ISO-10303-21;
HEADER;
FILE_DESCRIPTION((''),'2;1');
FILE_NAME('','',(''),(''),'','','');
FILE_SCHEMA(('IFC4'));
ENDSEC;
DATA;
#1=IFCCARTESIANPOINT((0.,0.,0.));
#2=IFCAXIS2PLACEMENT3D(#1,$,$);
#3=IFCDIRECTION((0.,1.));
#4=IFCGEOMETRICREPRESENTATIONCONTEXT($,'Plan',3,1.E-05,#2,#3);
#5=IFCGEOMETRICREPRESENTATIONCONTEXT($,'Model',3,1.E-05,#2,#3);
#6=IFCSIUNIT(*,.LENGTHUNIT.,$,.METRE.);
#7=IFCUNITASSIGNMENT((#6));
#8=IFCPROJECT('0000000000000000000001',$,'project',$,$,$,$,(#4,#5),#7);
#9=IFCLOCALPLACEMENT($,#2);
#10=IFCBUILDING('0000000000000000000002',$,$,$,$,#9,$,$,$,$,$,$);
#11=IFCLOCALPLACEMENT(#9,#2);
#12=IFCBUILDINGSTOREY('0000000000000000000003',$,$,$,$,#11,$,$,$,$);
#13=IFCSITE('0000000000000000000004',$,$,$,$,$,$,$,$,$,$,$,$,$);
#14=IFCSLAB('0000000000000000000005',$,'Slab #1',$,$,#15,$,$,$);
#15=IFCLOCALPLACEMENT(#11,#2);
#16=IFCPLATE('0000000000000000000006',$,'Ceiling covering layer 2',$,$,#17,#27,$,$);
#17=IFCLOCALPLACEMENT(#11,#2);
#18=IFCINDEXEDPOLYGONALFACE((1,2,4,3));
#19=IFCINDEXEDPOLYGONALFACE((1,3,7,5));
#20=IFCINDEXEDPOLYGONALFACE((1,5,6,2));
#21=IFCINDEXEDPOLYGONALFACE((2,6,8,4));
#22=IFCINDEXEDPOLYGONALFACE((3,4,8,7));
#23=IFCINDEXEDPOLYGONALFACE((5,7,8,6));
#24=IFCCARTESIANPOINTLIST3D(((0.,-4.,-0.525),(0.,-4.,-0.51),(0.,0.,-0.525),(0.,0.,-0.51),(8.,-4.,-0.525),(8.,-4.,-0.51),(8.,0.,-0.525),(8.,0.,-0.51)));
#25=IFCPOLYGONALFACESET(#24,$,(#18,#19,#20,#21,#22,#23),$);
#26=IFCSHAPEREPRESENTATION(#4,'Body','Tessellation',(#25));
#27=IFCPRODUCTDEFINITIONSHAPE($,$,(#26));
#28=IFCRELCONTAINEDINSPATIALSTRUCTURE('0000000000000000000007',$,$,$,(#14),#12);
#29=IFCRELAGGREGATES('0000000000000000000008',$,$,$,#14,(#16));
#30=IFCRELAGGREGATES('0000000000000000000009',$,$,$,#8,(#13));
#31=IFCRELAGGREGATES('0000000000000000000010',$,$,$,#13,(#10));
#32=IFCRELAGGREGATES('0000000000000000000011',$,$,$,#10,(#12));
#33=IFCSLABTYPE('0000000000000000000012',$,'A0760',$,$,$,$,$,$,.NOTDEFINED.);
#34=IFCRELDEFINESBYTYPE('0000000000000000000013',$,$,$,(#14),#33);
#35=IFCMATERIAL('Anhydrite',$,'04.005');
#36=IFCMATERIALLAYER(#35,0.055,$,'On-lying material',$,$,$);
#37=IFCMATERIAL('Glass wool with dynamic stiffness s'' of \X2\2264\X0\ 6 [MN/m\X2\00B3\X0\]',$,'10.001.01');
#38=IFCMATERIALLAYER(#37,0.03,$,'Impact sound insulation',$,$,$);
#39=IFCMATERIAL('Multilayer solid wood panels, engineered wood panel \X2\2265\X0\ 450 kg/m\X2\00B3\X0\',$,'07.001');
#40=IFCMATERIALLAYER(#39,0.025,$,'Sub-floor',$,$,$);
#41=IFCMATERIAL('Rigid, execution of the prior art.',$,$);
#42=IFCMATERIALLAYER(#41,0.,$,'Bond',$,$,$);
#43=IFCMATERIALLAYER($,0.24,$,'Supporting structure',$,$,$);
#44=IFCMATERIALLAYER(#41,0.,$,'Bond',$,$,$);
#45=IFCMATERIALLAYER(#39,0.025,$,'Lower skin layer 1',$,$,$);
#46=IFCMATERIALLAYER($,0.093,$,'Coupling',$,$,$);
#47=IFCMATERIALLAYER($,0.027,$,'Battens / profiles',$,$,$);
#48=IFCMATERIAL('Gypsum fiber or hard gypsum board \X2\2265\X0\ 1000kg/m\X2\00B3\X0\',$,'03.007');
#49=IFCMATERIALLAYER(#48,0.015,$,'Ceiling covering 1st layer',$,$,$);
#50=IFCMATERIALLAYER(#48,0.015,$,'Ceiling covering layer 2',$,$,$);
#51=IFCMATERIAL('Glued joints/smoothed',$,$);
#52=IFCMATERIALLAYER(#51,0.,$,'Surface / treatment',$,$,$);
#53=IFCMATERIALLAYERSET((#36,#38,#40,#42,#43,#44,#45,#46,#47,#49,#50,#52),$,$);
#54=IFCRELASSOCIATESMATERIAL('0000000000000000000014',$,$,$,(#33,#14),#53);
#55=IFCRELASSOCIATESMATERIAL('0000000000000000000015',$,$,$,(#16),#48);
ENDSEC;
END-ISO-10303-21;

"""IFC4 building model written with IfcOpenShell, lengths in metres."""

from ifc_helpers import new_model, si_unit, direction, frame, frame_2d, origin, place, context, project, spatial, rectangle, extrude, material, layer, layer_set, type_object, element, aggregate, save


model = new_model("IFC4")

# Units and contexts
plan_context = context("Plan", 3, precision=1e-05, world=origin(), true_north=direction((0.0, 1.0)))
model_context = context("Model", 3, precision=1e-05, world=origin(), true_north=direction((0.0, 1.0)))
ifc_project = project(units=[si_unit("LENGTHUNIT", "METRE")], contexts=[plan_context, model_context])

# Site, building, storey
site = spatial("IfcSite", under=ifc_project)
building_placement = place(None, origin())
building = spatial("IfcBuilding", under=site, at=building_placement)
storey_placement = place(building_placement, origin())
storey = spatial("IfcBuildingStorey", under=building, at=storey_placement)

# Slab, plate
ifc_material_1 = material(Name="Anhydrite", Category="04.005")
ifc_layer_1 = layer(ifc_material_1, 0.055, Name="On-lying material")
ifc_material_2 = material(Name="Glass wool with dynamic stiffness s' of ≤ 6 [MN/m³]", Category="10.001.01")
ifc_layer_2 = layer(ifc_material_2, 0.03, Name="Impact sound insulation")
ifc_material_3 = material(Name="Multilayer solid wood panels, engineered wood panel ≥ 450 kg/m³", Category="07.001")
ifc_layer_3 = layer(ifc_material_3, 0.025, Name="Sub-floor")
ifc_material_4 = material(Name="Rigid, execution of the prior art.")
ifc_layer_4 = layer(ifc_material_4, 0.0, Name="Bond")
ifc_layer_5 = layer(None, 0.24, Name="Supporting structure")
ifc_layer_6 = layer(ifc_material_4, 0.0, Name="Bond")
ifc_layer_7 = layer(ifc_material_3, 0.025, Name="Lower skin layer 1")
ifc_layer_8 = layer(None, 0.093, Name="Coupling")
ifc_layer_9 = layer(None, 0.027, Name="Battens / profiles")
ifc_material_5 = material(Name="Gypsum fiber or hard gypsum board ≥ 1000kg/m³", Category="03.007")
ifc_layer_10 = layer(ifc_material_5, 0.015, Name="Ceiling covering 1st layer")
ifc_layer_11 = layer(ifc_material_5, 0.015, Name="Ceiling covering layer 2")
ifc_material_6 = material(Name="Glued joints/smoothed")
ifc_layer_12 = layer(ifc_material_6, 0.0, Name="Surface / treatment")
ifc_layer_set = layer_set([ifc_layer_1, ifc_layer_2, ifc_layer_3, ifc_layer_4, ifc_layer_5, ifc_layer_6, ifc_layer_7, ifc_layer_8, ifc_layer_9, ifc_layer_10, ifc_layer_11, ifc_layer_12])
slab_type = type_object("IfcSlabType", Name="A0760", PredefinedType="NOTDEFINED", material=ifc_layer_set)
slab_placement = place(None, frame((0.0, 0.0, 0.0), z_axis=(0.0, 0.0, -1.0), x_axis=(1.0, 0.0, 0.0)))
slab = element("IfcSlab", 1, at=slab_placement, inside=storey, type_object=slab_type, material=ifc_layer_set, Name="Slab #1")
plate_1_placement = place(slab_placement, origin())
plate_1 = element("IfcPlate", 2, at=plate_1_placement, material=ifc_material_5, Name="Ceiling covering layer 2", context=plan_context, shape_type="SweptSolid", body=[
    extrude(rectangle(XDim=8.0, YDim=4.0, at=frame_2d((4.0, 2.0), x_axis=(1.0, 0.0))), frame((0.0, 0.0, 0.51), z_axis=(0.0, 0.0, 1.0), x_axis=(1.0, 0.0, 0.0)), (0.0, 0.0, 1.0), 0.015),
])
aggregate(slab, [plate_1])

save(model, "model.ifc")
